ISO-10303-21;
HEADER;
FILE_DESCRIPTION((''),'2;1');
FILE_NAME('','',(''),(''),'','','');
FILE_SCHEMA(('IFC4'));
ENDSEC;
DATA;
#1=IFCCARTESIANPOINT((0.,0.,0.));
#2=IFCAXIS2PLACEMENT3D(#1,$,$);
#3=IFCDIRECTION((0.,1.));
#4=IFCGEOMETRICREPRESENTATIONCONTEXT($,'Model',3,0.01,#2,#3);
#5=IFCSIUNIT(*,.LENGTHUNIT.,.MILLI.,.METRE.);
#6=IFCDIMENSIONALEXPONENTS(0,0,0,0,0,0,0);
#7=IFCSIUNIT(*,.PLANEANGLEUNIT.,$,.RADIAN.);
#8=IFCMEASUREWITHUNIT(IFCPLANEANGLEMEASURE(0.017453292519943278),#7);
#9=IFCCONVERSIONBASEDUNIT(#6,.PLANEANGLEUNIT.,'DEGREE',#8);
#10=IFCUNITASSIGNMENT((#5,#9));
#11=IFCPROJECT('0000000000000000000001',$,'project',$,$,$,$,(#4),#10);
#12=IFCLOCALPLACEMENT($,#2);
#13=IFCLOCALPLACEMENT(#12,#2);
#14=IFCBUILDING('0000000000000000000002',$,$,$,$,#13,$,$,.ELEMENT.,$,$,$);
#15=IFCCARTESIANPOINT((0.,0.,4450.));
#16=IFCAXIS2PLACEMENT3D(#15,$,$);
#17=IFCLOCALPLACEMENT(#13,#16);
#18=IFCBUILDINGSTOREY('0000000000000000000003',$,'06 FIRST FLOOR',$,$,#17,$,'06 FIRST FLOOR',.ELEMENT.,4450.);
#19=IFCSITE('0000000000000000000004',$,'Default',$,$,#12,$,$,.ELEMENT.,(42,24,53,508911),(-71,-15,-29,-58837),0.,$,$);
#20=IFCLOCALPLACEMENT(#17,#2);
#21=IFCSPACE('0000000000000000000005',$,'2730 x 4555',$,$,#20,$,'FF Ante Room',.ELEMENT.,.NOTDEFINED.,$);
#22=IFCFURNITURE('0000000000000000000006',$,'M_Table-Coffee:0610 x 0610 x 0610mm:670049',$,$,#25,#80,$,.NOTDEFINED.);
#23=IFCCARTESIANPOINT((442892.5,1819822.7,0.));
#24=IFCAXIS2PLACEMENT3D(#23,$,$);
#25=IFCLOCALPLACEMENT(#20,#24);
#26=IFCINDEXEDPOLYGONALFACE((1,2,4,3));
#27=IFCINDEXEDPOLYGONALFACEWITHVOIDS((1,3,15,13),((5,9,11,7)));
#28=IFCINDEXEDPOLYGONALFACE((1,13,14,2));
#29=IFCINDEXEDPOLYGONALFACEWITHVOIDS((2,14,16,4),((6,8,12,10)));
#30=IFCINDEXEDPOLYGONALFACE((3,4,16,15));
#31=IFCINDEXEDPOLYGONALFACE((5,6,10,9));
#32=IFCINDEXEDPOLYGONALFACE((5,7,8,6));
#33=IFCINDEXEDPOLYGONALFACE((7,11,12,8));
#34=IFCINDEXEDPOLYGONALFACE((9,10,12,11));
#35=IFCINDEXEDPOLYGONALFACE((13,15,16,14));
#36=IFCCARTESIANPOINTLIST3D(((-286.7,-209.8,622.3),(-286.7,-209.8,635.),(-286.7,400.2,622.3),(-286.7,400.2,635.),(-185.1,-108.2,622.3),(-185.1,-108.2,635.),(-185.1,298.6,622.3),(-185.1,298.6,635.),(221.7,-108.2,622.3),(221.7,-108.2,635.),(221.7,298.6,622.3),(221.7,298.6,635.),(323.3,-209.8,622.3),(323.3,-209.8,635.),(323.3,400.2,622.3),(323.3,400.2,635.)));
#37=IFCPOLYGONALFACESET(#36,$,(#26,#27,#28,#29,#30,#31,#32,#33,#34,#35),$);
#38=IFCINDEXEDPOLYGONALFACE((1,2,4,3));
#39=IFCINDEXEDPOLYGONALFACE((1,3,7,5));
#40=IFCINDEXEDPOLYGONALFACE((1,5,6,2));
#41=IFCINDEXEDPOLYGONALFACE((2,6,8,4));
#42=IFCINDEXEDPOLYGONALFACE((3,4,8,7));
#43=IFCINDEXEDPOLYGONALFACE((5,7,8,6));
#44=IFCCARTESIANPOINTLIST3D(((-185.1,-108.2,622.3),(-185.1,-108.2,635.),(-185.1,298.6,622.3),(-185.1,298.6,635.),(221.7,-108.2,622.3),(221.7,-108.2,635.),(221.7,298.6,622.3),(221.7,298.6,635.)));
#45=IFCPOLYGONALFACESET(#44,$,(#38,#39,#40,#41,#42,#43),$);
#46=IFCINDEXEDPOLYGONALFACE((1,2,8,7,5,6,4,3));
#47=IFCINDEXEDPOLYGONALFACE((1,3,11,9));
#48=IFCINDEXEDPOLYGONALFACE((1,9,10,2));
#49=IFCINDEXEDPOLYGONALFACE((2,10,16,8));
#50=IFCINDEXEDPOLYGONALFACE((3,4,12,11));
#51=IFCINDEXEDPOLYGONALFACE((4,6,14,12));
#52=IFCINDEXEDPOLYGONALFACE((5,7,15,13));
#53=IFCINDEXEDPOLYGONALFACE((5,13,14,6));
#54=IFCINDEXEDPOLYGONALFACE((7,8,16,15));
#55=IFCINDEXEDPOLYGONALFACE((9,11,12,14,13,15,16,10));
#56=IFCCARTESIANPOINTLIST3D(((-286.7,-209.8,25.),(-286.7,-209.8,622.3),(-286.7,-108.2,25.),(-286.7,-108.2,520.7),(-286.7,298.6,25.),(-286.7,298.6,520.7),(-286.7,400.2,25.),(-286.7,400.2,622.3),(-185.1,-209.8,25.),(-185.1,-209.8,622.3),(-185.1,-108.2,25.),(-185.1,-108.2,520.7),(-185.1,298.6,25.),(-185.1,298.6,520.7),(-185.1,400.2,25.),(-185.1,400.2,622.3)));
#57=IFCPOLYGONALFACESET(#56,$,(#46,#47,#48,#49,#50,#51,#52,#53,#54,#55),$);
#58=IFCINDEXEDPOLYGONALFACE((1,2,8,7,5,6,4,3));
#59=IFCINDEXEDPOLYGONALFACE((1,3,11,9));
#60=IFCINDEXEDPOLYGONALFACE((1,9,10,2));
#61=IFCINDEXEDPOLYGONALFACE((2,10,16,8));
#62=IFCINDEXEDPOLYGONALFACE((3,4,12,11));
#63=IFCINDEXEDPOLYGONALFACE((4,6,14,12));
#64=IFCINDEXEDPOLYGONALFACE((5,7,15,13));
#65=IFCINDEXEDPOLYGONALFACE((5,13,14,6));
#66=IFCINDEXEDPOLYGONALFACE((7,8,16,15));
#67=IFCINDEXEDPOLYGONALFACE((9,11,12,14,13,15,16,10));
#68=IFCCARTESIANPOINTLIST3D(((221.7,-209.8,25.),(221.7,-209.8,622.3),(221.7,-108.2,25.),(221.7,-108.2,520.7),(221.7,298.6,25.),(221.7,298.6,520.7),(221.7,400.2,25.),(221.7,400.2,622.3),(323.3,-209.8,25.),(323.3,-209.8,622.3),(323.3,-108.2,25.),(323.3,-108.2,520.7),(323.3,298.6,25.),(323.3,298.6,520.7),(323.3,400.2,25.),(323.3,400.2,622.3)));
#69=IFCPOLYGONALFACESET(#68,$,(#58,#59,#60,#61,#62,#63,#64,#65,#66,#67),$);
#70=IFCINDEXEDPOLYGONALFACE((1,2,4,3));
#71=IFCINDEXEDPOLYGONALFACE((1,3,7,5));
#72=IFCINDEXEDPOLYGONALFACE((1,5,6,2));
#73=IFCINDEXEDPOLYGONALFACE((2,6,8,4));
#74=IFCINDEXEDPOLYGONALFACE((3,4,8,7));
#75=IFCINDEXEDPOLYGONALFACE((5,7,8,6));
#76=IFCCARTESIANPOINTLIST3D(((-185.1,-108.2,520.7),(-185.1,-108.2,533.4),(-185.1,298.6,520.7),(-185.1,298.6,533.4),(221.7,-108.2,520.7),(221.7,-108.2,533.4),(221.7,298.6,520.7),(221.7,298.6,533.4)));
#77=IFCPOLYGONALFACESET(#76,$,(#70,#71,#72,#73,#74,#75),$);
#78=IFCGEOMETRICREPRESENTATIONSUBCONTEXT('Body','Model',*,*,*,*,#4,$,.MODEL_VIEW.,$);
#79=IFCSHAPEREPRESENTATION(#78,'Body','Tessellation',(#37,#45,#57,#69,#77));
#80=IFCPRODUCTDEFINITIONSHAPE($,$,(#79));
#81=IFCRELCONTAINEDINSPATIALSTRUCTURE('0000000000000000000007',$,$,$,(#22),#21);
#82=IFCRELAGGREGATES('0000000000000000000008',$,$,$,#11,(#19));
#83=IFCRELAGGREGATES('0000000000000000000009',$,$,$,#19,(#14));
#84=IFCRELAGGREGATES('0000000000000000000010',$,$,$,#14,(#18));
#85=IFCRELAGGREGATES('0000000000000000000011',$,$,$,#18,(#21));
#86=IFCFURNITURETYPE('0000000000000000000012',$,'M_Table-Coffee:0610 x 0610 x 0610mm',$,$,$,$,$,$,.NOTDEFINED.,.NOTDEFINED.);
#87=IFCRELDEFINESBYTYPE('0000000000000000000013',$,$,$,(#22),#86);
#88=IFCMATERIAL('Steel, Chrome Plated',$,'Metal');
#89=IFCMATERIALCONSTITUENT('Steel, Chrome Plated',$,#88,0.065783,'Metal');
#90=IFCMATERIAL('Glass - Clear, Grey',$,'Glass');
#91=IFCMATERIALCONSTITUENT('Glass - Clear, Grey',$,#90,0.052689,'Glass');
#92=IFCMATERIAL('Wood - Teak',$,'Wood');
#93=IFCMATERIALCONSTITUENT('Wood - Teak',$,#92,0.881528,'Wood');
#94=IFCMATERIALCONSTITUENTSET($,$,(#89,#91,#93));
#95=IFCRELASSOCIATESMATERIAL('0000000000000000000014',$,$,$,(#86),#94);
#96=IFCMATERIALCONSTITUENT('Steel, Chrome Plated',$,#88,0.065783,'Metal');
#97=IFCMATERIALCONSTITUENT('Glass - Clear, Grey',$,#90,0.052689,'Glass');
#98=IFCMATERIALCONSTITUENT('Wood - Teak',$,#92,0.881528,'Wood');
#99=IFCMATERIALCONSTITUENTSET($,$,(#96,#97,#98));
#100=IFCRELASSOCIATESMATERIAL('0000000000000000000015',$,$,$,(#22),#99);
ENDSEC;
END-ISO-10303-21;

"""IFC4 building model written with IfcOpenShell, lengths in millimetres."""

from ifc_helpers import new_model, entity, si_unit, converted_unit, direction, frame, origin, place, context, subcontext, project, spatial, indexed_curve, outline, extrude, source, transform, mapped, material, constituent, constituent_set, type_object, type_shapes, element, save


model = new_model("IFC4")

# Units and contexts
model_context = context("Model", 3, precision=0.01, world=origin(), true_north=direction((0.0, 1.0)))
body_context = subcontext(model_context, "Body", "Model", "MODEL_VIEW")
ifc_project = project(units=[si_unit("LENGTHUNIT", "METRE", prefix="MILLI"), converted_unit("PLANEANGLEUNIT", "DEGREE", entity("IfcPlaneAngleMeasure", 0.017453292519943278), si_unit("PLANEANGLEUNIT", "RADIAN"), dimensions=[0, 0, 0, 0, 0, 0, 0])], contexts=[model_context])

# Site, building, storey
site_placement = place(None, origin())
site = spatial("IfcSite", under=ifc_project, at=site_placement, Name="Default", CompositionType="ELEMENT", RefLatitude=(42, 24, 53, 508911), RefLongitude=(-71, -15, -29, -58837), RefElevation=0.0)
building_placement = place(site_placement, origin())
building = spatial("IfcBuilding", under=site, at=building_placement, CompositionType="ELEMENT")
storey_placement = place(building_placement, frame((0.0, 0.0, 4450.0)))
storey = spatial("IfcBuildingStorey", under=building, at=storey_placement, Name="06 FIRST FLOOR", LongName="06 FIRST FLOOR", CompositionType="ELEMENT", Elevation=4450.0)

# Shared definitions
space_placement = place(storey_placement, origin())
space = spatial("IfcSpace", under=storey, at=space_placement, Name="2730 x 4555", LongName="FF Ante Room", CompositionType="ELEMENT", PredefinedType="NOTDEFINED")

# Furniture
ifc_material_1 = material(Name="Steel, Chrome Plated", Category="Metal")
ifc_constituent_1 = constituent(ifc_material_1, Name="Steel, Chrome Plated", Category="Metal", fraction=0.065783)
ifc_material_2 = material(Name="Glass - Clear, Grey", Category="Glass")
ifc_constituent_2 = constituent(ifc_material_2, Name="Glass - Clear, Grey", Category="Glass", fraction=0.052689)
ifc_material_3 = material(Name="Wood - Teak", Category="Wood")
ifc_constituent_3 = constituent(ifc_material_3, Name="Wood - Teak", Category="Wood", fraction=0.881528)
ifc_constituent_set_1 = constituent_set(constituents=[ifc_constituent_1, ifc_constituent_2, ifc_constituent_3])
ifc_constituent_4 = constituent(ifc_material_1, Name="Steel, Chrome Plated", Category="Metal", fraction=0.065783)
ifc_constituent_5 = constituent(ifc_material_2, Name="Glass - Clear, Grey", Category="Glass", fraction=0.052689)
ifc_constituent_6 = constituent(ifc_material_3, Name="Wood - Teak", Category="Wood", fraction=0.881528)
ifc_constituent_set_2 = constituent_set(constituents=[ifc_constituent_4, ifc_constituent_5, ifc_constituent_6])
furniture_type_1 = type_object("IfcFurnitureType", Name="M_Table-Coffee:0610 x 0610 x 0610mm", AssemblyPlace="NOTDEFINED", PredefinedType="NOTDEFINED", material=ifc_constituent_set_2)
shared_shape_1 = source(origin(), body_context, "Body", "SweptSolid", [
    extrude(outline(indexed_curve([(-305.0, -305.0), (305.0, -305.0), (305.0, 305.0), (-305.0, 305.0), (-305.0, -305.0)], self_intersect=False), holes=[indexed_curve([(-203.4, -203.4), (-203.4, 203.4), (203.4, 203.4), (203.4, -203.4), (-203.4, -203.4)], self_intersect=False)]), frame((18.3, 95.2, 622.3), z_axis=(0.0, 0.0, 1.0), x_axis=(-1.0, 0.0, 0.0)), (0.0, 0.0, 1.0), 12.7),
    extrude(outline(indexed_curve([(-203.4, -203.4), (203.4, -203.4), (203.4, 203.4), (-203.4, 203.4), (-203.4, -203.4)], self_intersect=False)), frame((18.3, 95.2, 622.3), z_axis=(0.0, 0.0, 1.0), x_axis=(-1.0, 0.0, 0.0)), (0.0, 0.0, 1.0), 12.7),
    extrude(outline(indexed_curve([(-305.0, -324.1), (305.0, -324.1), (305.0, 273.3), (203.4, 273.3), (203.4, -222.4), (-203.4, -222.4), (-203.4, 273.3), (-305.0, 273.3), (-305.0, -324.1)], self_intersect=False)), frame((-286.7, 95.2, 298.3), z_axis=(1.0, 0.0, 0.0), x_axis=(0.0, -1.0, 0.0)), (0.0, 0.0, 1.0), 101.6),
    extrude(outline(indexed_curve([(-273.2, -305.0), (324.0, -305.0), (324.0, 305.0), (-273.2, 305.0), (-273.2, 203.4), (222.5, 203.4), (222.5, -203.4), (-273.2, -203.4), (-273.2, -305.0)], self_intersect=False)), frame((221.7, 95.2, 298.2), z_axis=(1.0, 0.0, 0.0), x_axis=(0.0, 0.0, 1.0)), (0.0, 0.0, 1.0), 101.6),
    extrude(outline(indexed_curve([(-203.4, -203.4), (203.4, -203.4), (203.4, 203.4), (-203.4, 203.4), (-203.4, -203.4)], self_intersect=False)), frame((18.3, 95.2, 520.7), z_axis=(0.0, 0.0, 1.0), x_axis=(-1.0, 0.0, 0.0)), (0.0, 0.0, 1.0), 12.7),
])
type_shapes(furniture_type_1, [shared_shape_1])
furniture_1_placement = place(space_placement, frame((442892.5, 1819822.7, 0.0)))
element("IfcFurniture", 1, at=furniture_1_placement, inside=space, type_object=furniture_type_1, material=ifc_constituent_set_1, Name="M_Table-Coffee:0610 x 0610 x 0610mm:670049", PredefinedType="NOTDEFINED", context=body_context, shape_type="MappedRepresentation", body=[
    mapped(shared_shape_1, transform((0.0, 0.0, 0.0), scale=1.0)),
])

save(model, "model.ifc")
